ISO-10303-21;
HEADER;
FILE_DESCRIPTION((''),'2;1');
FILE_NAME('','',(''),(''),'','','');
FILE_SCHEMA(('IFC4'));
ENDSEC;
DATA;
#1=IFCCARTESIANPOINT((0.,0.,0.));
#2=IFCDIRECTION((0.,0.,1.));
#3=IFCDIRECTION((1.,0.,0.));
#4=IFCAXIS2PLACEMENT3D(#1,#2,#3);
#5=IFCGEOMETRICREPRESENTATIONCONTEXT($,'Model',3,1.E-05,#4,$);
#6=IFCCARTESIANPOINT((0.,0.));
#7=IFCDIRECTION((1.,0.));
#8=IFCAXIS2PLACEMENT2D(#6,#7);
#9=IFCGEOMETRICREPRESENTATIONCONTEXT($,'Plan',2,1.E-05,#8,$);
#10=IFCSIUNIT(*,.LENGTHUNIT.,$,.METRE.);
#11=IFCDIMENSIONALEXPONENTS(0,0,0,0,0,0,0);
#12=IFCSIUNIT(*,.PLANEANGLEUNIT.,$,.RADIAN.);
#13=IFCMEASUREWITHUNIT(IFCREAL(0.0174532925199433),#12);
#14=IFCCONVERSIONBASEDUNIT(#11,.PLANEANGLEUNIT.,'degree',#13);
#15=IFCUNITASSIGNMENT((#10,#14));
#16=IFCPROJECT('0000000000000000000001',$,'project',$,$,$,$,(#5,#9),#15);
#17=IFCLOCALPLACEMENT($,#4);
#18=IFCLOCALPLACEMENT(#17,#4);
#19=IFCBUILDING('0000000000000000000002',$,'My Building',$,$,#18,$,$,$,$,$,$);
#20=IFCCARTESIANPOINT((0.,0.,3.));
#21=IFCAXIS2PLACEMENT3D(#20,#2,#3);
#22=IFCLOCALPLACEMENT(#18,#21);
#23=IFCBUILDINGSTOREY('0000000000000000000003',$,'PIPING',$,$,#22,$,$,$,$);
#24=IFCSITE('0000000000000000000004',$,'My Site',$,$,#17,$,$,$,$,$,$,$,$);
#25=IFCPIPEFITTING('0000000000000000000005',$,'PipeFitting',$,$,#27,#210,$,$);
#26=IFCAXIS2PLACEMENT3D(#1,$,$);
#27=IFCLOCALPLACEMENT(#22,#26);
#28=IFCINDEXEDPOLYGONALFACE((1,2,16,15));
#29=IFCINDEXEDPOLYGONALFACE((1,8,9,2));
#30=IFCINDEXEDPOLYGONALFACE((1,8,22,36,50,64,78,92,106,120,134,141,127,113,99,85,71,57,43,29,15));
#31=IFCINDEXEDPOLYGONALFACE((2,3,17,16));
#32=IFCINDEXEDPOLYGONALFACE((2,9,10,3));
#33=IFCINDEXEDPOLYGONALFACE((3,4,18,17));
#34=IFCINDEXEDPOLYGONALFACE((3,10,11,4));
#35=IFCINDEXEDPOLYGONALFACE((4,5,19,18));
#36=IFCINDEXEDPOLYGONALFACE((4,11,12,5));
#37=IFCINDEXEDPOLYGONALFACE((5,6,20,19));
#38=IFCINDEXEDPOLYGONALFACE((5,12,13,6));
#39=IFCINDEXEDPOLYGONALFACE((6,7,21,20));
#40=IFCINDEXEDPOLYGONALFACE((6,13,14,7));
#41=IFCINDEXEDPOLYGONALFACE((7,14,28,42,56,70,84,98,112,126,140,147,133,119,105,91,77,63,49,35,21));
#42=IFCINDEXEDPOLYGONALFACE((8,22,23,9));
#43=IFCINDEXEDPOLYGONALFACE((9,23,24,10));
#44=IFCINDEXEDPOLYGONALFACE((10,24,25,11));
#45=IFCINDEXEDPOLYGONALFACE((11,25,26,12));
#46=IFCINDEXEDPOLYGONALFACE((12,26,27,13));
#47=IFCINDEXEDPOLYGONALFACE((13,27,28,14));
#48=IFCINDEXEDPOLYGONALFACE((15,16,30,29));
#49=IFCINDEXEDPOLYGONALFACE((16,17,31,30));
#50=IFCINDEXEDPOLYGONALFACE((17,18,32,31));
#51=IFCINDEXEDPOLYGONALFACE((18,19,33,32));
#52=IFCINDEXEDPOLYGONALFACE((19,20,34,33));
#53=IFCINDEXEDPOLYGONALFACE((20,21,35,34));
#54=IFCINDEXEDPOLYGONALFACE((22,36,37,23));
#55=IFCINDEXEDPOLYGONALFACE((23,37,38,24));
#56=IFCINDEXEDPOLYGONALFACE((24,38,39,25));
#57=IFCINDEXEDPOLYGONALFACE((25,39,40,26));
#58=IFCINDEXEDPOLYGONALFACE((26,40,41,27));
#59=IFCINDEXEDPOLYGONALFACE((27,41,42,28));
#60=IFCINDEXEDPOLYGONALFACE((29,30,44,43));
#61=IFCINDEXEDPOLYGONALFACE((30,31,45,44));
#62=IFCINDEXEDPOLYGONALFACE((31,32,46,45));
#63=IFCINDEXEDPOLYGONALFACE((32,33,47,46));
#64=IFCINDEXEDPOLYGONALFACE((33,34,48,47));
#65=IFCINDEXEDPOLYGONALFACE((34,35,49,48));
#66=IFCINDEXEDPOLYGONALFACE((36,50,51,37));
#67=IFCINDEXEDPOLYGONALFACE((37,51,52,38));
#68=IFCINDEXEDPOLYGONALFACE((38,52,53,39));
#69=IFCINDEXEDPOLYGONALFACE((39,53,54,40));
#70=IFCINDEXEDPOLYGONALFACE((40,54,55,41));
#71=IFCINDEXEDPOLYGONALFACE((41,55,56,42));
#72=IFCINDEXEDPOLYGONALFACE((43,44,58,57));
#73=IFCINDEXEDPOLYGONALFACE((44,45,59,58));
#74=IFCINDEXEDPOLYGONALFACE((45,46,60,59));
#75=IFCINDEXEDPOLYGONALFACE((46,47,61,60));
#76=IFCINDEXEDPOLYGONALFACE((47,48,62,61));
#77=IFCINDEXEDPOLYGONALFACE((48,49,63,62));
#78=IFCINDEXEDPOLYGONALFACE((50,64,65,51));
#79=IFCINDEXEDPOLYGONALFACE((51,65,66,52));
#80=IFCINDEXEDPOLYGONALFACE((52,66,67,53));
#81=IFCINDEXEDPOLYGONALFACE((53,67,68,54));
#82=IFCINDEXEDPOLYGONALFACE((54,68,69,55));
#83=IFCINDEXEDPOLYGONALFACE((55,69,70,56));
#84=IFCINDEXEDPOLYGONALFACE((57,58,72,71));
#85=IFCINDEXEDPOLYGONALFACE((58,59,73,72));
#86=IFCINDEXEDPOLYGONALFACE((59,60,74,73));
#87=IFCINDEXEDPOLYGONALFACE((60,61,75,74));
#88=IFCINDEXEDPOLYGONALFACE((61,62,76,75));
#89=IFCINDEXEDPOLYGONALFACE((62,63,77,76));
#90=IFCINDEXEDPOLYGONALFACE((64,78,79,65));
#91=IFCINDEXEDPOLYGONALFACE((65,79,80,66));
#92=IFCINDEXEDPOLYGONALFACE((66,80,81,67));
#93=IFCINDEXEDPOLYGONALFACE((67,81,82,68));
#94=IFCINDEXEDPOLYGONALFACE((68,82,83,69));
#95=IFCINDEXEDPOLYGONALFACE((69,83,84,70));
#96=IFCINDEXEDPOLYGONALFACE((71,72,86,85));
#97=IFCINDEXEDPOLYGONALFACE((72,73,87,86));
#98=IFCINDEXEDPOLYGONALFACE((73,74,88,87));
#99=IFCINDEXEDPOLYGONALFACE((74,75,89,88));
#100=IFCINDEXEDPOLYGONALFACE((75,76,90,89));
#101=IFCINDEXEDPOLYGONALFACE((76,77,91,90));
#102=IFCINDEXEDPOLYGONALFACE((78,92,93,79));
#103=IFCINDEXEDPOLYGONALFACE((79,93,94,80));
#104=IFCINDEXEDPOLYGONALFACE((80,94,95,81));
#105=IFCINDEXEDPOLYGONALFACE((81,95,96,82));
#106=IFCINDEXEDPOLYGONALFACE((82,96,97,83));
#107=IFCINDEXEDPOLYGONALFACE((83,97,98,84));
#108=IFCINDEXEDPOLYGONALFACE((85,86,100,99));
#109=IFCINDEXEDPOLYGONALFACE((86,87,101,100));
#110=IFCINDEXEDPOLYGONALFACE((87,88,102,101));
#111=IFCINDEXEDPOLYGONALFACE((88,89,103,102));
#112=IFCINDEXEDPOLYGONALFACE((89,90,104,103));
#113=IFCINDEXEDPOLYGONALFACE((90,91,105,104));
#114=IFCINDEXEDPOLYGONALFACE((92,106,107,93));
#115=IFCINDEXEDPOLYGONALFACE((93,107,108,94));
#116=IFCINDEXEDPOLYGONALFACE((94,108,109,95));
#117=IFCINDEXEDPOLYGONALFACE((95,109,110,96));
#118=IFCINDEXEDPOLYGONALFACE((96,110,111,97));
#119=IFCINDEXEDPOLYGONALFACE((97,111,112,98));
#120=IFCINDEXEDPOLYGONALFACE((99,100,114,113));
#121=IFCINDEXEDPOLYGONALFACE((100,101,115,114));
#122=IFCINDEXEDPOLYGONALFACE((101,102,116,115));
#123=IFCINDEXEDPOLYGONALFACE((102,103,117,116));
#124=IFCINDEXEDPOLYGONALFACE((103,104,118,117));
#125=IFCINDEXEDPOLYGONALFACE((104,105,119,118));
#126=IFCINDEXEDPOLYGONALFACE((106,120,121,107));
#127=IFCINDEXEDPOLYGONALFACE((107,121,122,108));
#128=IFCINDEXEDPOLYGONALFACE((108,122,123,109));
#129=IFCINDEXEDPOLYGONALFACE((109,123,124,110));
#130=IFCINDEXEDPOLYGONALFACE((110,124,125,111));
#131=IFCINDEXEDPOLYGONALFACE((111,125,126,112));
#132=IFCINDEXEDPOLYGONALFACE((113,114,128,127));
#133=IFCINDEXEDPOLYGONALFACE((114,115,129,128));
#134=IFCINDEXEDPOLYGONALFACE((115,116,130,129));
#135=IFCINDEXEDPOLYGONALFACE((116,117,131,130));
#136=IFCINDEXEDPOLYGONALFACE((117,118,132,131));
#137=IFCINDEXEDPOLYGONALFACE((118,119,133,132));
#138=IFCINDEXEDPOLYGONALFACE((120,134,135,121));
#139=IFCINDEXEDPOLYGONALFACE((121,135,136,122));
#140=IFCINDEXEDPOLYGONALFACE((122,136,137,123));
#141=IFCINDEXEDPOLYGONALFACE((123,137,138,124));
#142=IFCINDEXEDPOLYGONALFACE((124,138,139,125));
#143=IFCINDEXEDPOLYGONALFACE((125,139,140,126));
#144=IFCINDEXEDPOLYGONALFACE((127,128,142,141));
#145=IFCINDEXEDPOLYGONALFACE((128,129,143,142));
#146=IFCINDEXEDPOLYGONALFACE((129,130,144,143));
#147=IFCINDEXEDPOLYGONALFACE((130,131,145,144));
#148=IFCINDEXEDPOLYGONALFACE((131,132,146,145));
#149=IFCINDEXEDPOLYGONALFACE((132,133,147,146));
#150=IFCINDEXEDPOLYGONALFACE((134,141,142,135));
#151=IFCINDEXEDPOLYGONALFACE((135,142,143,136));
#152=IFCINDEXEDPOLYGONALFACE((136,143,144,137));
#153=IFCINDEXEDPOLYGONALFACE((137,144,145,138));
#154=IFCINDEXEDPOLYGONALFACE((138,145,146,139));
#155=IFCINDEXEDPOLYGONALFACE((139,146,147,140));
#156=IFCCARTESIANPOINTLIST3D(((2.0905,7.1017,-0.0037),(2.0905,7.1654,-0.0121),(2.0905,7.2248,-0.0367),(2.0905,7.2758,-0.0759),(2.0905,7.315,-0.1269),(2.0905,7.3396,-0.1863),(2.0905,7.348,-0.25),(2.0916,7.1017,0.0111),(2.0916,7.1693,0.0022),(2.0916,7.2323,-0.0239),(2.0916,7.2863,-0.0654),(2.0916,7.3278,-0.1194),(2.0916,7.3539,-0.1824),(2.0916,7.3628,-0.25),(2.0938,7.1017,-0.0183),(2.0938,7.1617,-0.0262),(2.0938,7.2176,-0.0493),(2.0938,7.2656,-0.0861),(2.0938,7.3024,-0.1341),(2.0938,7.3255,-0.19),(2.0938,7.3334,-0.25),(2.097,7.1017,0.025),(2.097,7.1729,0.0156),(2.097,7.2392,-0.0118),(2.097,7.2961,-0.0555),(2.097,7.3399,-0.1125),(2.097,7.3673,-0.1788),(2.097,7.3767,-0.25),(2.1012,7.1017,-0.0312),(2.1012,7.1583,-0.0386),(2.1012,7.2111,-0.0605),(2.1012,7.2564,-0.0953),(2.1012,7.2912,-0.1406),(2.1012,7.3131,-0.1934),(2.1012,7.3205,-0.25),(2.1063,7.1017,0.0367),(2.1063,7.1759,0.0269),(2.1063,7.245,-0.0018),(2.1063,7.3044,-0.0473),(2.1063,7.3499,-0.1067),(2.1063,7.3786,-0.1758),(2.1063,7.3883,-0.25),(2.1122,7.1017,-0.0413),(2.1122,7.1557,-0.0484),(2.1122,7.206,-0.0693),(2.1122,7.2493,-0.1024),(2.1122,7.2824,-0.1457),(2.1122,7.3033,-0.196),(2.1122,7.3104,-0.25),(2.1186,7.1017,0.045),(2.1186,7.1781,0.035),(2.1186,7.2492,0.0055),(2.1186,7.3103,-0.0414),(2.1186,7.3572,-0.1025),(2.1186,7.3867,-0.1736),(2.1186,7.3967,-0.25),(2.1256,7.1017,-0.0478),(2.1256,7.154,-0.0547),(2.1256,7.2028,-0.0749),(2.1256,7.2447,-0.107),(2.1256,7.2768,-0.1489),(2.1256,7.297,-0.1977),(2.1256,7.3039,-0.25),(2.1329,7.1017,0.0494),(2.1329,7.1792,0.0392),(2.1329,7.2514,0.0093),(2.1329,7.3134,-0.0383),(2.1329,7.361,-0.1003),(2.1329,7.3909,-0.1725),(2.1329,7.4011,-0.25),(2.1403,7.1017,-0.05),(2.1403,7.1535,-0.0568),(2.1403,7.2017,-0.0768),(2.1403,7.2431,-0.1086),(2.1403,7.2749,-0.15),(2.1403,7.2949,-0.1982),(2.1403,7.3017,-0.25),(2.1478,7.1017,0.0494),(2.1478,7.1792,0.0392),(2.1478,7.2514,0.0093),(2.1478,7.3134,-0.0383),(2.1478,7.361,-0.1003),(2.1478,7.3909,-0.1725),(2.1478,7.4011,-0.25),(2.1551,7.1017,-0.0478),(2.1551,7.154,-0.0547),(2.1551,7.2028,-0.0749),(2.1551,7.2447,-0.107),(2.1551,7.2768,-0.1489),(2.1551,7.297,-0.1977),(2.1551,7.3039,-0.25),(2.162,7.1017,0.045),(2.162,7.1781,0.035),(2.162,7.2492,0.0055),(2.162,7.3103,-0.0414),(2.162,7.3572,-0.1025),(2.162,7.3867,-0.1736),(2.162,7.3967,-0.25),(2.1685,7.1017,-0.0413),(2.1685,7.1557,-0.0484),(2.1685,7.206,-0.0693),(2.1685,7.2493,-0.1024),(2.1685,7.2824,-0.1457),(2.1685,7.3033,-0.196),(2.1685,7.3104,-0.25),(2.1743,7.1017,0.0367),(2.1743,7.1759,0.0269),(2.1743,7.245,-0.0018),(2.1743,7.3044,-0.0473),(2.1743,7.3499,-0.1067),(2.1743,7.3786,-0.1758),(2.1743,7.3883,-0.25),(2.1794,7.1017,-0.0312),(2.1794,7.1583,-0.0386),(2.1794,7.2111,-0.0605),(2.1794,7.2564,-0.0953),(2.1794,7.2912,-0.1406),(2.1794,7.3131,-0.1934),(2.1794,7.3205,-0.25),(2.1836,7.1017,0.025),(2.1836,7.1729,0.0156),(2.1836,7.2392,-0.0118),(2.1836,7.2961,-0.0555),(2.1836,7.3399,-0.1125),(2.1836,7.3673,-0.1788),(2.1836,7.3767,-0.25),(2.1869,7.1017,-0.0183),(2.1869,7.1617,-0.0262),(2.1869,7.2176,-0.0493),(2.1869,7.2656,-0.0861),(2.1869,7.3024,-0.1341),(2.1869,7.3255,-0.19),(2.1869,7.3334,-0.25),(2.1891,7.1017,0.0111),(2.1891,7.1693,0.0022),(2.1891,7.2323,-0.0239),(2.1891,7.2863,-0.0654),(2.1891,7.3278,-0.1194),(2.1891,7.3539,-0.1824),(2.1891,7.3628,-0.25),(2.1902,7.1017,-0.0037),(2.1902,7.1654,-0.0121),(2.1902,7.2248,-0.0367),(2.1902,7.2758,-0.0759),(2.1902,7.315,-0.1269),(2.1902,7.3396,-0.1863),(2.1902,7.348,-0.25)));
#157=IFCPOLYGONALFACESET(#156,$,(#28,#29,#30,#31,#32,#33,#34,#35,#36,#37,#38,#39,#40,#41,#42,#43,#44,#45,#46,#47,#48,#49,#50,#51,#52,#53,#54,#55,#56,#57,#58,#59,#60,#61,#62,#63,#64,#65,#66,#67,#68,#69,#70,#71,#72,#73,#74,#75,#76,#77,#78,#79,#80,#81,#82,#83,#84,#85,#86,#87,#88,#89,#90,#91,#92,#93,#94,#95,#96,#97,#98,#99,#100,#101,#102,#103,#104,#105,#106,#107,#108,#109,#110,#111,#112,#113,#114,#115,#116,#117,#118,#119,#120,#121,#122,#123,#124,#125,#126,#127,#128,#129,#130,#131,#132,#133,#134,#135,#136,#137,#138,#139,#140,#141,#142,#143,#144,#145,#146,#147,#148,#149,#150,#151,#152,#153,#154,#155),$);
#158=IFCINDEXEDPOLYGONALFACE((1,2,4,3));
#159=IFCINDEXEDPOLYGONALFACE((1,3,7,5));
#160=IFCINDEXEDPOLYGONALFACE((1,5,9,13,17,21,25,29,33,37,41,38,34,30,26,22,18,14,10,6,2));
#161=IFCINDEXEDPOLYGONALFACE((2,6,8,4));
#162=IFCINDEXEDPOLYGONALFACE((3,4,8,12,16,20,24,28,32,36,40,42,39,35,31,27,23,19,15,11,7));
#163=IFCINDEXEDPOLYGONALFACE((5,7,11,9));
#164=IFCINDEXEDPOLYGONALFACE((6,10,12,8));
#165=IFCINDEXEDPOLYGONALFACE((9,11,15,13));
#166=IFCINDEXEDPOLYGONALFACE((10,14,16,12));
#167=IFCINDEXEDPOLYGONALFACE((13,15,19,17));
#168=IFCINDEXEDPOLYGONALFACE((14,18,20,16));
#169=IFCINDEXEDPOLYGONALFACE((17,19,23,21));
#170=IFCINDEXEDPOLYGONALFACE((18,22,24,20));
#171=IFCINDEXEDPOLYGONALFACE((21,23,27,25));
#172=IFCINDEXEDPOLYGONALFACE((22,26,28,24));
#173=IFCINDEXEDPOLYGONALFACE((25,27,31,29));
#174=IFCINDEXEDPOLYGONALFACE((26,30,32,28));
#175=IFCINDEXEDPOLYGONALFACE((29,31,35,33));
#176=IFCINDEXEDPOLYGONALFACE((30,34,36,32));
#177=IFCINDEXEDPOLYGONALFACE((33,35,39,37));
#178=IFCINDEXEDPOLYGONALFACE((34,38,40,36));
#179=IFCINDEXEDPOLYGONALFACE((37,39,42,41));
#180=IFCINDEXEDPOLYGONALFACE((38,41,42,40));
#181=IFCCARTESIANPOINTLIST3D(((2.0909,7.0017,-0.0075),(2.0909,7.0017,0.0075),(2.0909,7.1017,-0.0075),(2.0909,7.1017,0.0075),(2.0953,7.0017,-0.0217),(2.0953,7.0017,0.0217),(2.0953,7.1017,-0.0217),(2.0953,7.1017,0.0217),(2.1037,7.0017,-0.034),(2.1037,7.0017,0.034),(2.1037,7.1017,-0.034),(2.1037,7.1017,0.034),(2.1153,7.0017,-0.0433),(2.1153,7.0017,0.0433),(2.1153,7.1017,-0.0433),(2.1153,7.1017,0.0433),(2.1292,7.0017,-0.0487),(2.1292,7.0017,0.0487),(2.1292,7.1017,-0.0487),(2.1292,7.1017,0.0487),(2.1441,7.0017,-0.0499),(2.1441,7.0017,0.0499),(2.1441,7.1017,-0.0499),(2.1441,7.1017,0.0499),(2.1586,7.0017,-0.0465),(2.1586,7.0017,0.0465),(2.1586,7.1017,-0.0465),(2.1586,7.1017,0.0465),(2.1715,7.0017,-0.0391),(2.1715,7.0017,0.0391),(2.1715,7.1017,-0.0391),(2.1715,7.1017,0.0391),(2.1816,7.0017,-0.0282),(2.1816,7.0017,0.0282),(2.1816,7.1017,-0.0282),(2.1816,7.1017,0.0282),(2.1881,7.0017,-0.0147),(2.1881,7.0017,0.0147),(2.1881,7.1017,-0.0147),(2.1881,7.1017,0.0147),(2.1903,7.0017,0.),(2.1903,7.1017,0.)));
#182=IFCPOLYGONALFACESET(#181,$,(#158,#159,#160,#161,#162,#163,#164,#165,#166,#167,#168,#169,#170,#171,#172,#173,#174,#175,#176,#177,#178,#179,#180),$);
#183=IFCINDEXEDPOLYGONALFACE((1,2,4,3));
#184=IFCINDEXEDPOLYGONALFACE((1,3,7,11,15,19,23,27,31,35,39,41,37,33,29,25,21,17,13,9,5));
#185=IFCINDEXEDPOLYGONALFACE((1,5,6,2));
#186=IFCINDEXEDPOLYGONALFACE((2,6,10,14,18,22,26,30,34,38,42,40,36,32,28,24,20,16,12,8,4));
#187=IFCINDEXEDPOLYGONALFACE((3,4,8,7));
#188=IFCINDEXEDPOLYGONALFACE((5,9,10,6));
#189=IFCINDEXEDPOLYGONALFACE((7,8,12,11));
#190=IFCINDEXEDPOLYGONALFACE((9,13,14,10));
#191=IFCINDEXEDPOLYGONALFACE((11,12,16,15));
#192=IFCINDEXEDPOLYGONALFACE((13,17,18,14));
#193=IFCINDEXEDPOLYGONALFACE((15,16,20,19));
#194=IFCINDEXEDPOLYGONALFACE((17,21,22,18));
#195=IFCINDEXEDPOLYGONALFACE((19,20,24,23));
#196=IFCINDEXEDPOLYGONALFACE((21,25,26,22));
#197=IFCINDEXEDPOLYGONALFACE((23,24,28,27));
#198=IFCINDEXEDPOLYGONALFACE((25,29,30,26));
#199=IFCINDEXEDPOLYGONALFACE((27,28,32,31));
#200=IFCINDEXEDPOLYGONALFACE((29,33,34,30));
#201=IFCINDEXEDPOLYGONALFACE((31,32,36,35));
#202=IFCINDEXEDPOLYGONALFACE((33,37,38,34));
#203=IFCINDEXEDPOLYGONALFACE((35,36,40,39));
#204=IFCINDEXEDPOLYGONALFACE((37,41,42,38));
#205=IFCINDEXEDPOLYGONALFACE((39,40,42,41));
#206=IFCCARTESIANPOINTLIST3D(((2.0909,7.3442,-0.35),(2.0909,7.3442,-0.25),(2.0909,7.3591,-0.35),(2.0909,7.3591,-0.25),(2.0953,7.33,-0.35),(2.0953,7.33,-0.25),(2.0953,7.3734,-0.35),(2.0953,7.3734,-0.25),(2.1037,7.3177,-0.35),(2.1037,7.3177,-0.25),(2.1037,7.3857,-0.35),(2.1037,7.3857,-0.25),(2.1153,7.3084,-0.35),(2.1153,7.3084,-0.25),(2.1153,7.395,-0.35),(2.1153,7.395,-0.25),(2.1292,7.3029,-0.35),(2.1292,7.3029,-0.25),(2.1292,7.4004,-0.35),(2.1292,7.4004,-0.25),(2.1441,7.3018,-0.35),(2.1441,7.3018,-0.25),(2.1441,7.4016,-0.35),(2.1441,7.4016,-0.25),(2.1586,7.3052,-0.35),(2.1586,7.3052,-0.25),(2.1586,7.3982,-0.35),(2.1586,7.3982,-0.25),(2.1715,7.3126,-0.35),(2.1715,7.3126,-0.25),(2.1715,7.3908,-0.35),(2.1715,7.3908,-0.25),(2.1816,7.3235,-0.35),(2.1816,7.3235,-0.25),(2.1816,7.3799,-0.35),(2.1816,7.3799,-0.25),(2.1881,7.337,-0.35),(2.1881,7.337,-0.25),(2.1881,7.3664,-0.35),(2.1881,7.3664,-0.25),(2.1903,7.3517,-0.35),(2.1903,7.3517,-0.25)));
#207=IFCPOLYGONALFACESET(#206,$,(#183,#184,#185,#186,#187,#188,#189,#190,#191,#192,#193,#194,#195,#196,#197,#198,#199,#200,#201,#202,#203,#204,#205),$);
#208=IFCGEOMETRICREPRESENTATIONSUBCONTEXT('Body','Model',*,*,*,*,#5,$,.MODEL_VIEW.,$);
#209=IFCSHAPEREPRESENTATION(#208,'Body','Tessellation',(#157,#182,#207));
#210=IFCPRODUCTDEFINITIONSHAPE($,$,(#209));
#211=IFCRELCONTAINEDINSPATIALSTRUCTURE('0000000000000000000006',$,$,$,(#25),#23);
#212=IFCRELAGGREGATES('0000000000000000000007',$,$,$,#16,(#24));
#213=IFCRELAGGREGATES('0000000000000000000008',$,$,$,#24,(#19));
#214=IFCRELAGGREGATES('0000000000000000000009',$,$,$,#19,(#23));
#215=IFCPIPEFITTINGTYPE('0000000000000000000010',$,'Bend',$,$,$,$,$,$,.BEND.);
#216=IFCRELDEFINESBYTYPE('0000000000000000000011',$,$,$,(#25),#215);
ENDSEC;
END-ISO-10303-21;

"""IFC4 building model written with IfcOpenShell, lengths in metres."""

from ifc_helpers import new_model, entity, si_unit, converted_unit, frame, origin_with_axes, origin_2d_with_axis, place, context, subcontext, project, spatial, circle, extrude, source, transform, mapped, type_object, type_shapes, element, save


model = new_model("IFC4")

# Units and contexts
model_context = context("Model", 3, precision=1e-05, world=origin_with_axes())
plan_context = context("Plan", 2, precision=1e-05, world=origin_2d_with_axis())
body_context = subcontext(model_context, "Body", "Model", "MODEL_VIEW")
ifc_project = project(units=[si_unit("LENGTHUNIT", "METRE"), converted_unit("PLANEANGLEUNIT", "degree", entity("IfcReal", 0.0174532925199433), si_unit("PLANEANGLEUNIT", "RADIAN"), dimensions=[0, 0, 0, 0, 0, 0, 0])], contexts=[model_context, plan_context])

# Site, building, storey
site_placement = place(None, origin_with_axes())
site = spatial("IfcSite", under=ifc_project, at=site_placement, Name="My Site")
building_placement = place(site_placement, origin_with_axes())
building = spatial("IfcBuilding", under=site, at=building_placement, Name="My Building")
storey_placement = place(building_placement, frame((0.0, 0.0, 3.0), z_axis=(0.0, 0.0, 1.0), x_axis=(1.0, 0.0, 0.0)))
storey = spatial("IfcBuildingStorey", under=building, at=storey_placement, Name="PIPING")

# Pipe fitting
pipe_fitting_type = type_object("IfcPipeFittingType", Name="Bend", PredefinedType="BEND")
shared_shape = source(origin_with_axes(), body_context, "Body", "SolidModel", [
    entity("IfcSweptDiskSolid", entity("IfcIndexedPolyCurve", entity("IfcCartesianPointList3D", [[0.0, 0.0, -0.1], [0.0, -0.0732, -0.2768], [0.0, -0.25, -0.35]]), [entity("IfcArcIndex", [1, 2, 3])]), 0.05),
    extrude(circle(Radius=0.05), origin_with_axes(), (0.0, 0.0, -1.0), 0.1),
    extrude(circle(Radius=0.05), frame((0.0, -0.25, -0.35), z_axis=(0.0, -1.0, 0.0), x_axis=(1.0, 0.0, 0.0)), (0.0, 0.0, 1.0), 0.1),
])
type_shapes(pipe_fitting_type, [shared_shape])
for number, where, z_axis, x_axis, name in (
    (1, (2.1403, 7.0017, 0.0), (0.0, -1.0, 0.0), (1.0, 0.0, 0.0), "PipeFitting"),
):
    element("IfcPipeFitting", number, at=place(storey_placement, frame(where, z_axis=z_axis, x_axis=x_axis)), inside=storey, type_object=pipe_fitting_type, Name=name, context=body_context, shape_type="MappedRepresentation", body=[
        mapped(shared_shape, transform((0.0, 0.0, 0.0), x_axis=(1.0, 0.0, 0.0), y_axis=(0.0, 1.0, 0.0), z_axis=(0.0, 0.0, 1.0), scale=1.0)),
    ])

save(model, "model.ifc")
